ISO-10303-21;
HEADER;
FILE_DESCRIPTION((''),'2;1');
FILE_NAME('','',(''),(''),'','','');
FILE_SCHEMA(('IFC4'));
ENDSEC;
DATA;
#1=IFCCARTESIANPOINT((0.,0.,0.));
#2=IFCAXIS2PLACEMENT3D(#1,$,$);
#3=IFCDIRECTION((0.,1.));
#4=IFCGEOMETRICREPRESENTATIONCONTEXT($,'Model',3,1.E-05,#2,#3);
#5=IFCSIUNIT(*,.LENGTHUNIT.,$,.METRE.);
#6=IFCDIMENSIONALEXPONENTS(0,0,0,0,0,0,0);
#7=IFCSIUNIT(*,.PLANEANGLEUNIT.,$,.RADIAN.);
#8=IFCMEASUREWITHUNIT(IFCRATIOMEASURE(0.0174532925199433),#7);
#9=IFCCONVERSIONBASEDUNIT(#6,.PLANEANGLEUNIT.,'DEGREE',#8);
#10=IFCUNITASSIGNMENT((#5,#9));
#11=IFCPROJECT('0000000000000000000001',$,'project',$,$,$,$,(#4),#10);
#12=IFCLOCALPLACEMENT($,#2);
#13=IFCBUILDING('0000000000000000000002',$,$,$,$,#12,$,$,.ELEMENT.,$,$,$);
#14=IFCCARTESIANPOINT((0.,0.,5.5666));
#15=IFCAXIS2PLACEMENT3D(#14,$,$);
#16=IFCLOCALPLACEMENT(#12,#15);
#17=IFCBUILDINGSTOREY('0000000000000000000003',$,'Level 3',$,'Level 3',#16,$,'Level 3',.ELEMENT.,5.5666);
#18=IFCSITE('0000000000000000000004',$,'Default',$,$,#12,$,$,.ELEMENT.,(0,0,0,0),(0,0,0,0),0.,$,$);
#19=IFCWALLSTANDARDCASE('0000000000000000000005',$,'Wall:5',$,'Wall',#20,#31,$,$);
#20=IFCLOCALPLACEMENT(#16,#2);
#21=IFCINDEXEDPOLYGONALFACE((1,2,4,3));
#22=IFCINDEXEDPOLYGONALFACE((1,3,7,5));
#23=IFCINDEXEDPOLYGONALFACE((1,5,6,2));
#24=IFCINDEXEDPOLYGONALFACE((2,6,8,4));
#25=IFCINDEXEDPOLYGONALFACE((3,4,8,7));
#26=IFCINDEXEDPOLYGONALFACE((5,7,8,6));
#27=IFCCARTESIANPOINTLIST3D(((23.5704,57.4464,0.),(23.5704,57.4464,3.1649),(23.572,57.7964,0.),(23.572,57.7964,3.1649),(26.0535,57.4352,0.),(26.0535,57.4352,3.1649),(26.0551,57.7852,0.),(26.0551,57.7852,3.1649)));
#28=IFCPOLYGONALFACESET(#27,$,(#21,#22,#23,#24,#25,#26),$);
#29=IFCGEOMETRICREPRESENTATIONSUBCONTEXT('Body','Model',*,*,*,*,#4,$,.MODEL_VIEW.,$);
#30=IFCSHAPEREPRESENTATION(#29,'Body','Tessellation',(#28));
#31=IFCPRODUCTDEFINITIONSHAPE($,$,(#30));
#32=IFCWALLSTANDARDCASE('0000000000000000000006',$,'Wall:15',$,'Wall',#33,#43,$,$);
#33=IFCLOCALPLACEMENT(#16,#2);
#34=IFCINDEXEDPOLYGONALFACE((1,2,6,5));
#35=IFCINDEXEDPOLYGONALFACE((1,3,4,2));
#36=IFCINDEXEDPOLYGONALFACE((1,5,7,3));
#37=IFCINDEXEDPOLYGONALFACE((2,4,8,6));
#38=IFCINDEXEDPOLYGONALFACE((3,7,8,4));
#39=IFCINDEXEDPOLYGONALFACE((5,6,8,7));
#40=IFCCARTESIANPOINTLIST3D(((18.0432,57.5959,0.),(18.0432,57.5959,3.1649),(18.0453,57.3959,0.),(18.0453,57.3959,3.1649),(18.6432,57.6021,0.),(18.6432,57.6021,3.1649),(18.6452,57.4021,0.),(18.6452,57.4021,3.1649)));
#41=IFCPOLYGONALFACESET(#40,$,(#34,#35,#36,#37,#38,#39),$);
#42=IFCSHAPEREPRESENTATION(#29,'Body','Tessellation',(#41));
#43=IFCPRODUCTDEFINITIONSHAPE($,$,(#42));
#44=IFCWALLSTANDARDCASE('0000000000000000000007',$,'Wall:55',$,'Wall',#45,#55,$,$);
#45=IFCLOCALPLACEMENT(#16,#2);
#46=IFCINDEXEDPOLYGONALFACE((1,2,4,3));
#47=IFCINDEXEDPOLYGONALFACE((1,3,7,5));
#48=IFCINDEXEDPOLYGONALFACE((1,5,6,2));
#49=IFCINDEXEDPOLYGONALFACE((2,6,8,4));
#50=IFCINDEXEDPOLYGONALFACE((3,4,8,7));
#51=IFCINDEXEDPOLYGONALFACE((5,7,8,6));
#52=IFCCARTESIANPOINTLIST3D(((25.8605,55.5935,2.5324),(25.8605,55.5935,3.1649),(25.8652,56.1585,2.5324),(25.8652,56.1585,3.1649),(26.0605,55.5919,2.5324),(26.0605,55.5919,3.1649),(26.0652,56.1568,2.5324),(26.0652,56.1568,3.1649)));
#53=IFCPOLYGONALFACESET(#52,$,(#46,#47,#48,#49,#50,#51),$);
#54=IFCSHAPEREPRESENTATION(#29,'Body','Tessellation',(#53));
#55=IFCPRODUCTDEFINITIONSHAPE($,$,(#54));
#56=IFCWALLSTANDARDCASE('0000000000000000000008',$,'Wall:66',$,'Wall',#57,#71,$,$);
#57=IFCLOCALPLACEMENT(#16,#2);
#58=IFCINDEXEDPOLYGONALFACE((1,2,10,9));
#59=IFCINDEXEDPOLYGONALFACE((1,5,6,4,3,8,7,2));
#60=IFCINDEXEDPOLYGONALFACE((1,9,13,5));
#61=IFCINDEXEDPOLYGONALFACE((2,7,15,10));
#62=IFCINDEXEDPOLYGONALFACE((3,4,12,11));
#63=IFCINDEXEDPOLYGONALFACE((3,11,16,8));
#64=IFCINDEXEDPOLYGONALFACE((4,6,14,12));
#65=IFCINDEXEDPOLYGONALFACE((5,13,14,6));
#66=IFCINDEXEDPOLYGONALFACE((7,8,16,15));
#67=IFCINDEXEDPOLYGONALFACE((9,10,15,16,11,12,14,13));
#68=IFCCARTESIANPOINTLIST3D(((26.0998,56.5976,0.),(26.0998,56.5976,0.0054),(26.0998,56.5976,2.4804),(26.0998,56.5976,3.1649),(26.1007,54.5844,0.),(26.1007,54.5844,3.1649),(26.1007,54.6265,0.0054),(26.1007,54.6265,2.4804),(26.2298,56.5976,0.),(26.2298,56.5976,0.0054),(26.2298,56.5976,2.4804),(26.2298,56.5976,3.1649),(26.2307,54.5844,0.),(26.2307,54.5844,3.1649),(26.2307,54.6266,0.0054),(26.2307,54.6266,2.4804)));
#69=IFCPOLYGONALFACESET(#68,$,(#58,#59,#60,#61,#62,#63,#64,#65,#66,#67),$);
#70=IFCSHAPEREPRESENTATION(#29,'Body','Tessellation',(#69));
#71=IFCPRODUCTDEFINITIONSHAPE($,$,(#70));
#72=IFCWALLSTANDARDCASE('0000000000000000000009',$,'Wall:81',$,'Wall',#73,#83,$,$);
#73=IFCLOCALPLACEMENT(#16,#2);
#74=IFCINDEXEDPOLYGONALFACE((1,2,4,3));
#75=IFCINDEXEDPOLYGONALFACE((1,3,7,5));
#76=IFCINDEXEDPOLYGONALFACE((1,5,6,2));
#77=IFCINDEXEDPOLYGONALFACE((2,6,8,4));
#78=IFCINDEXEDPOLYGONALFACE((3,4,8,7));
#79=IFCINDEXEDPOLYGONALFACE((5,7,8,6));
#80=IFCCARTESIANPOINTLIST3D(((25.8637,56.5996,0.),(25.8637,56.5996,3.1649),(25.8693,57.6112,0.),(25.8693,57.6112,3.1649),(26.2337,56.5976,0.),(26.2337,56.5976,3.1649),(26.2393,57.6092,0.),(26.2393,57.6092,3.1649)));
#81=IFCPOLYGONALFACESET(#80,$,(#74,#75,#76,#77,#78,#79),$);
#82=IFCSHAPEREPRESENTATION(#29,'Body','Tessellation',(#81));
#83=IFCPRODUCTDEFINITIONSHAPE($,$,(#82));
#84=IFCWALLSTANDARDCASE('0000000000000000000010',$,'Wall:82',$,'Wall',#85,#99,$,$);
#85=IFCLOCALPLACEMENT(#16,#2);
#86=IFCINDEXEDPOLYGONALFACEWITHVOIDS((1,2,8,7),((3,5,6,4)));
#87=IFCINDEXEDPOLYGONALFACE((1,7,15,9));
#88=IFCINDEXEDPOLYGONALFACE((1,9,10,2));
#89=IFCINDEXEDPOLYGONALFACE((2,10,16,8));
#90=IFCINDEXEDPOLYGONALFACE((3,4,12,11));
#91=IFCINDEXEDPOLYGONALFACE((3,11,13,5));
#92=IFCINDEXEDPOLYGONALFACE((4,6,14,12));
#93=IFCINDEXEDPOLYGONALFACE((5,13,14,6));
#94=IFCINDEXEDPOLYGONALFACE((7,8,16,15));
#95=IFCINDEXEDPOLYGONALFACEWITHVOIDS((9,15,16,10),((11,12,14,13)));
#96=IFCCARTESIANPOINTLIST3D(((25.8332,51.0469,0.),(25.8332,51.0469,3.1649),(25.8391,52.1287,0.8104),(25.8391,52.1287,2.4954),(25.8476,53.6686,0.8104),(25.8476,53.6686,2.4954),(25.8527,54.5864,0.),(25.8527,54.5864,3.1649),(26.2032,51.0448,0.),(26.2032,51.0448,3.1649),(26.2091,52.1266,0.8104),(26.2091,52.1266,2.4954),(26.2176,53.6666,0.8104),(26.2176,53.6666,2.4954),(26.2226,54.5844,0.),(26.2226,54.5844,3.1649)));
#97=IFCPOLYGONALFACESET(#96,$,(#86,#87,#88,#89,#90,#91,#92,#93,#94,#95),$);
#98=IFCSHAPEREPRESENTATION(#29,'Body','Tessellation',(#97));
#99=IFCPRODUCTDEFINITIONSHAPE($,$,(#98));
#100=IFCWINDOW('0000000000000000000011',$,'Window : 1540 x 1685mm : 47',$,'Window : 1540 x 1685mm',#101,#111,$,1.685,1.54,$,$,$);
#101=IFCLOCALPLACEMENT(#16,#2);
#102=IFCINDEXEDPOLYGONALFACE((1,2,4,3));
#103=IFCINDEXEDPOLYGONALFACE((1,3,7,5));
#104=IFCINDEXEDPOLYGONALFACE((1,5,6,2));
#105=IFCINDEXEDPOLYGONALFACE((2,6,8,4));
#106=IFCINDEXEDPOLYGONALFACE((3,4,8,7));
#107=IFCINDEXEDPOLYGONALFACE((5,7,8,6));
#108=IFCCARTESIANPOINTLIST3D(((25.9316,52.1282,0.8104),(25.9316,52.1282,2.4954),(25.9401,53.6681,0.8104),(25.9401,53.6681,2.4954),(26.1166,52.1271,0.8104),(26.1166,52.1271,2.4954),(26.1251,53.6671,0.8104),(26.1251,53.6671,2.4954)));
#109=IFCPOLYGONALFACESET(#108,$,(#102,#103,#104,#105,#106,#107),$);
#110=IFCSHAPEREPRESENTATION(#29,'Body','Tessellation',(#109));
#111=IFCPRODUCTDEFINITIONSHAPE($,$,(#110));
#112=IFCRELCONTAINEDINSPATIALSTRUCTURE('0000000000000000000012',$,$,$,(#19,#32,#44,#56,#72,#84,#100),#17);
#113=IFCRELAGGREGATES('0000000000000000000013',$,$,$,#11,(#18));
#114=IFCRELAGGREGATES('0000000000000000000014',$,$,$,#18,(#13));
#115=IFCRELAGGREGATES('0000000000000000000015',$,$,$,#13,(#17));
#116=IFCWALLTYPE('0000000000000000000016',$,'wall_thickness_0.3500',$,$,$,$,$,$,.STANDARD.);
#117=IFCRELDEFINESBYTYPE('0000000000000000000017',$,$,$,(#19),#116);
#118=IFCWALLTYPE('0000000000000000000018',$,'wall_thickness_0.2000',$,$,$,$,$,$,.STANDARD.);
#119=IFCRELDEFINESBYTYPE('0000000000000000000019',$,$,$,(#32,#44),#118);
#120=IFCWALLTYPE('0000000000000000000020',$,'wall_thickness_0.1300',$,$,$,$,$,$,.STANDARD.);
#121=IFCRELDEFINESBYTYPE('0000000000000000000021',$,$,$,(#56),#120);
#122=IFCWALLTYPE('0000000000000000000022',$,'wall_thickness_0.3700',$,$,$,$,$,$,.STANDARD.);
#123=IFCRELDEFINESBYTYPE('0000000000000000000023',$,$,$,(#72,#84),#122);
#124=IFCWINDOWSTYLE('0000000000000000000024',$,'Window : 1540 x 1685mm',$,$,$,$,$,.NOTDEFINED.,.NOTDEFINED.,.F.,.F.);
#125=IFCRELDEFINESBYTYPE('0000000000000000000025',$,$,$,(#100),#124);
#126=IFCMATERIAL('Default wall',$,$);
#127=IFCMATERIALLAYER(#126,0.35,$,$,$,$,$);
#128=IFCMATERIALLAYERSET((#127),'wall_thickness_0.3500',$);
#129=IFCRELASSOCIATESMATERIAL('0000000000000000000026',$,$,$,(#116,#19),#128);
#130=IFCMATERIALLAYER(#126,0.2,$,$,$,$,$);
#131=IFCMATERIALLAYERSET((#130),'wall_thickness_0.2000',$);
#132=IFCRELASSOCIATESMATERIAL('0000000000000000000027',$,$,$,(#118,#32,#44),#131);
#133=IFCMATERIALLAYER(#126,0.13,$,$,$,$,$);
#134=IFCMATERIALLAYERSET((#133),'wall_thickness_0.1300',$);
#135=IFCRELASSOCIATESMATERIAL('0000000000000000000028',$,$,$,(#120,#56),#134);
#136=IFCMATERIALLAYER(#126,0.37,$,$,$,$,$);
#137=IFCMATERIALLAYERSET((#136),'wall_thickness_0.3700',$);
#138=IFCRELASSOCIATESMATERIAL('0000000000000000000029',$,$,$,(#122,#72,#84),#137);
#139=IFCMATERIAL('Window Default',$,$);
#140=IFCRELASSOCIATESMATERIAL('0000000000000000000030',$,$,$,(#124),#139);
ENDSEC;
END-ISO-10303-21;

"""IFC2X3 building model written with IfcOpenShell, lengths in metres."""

from ifc_helpers import new_model, entity, si_unit, converted_unit, direction, frame, frame_2d, origin, origin_2d_with_axis, place, context, subcontext, project, spatial, polyline, rectangle, outline, extrude, source, transform, mapped, material, layer, layer_set, layer_usage, type_object, type_shapes, element, fill, save


model = new_model("IFC2X3")

# Units and contexts
model_context = context("Model", 3, precision=1e-05, world=origin(), true_north=direction((0.0, 1.0)))
body_context = subcontext(model_context, "Body", "Model", "MODEL_VIEW")
ifc_project = project(units=[si_unit("LENGTHUNIT", "METRE"), converted_unit("PLANEANGLEUNIT", "DEGREE", entity("IfcRatioMeasure", 0.0174532925199433), si_unit("PLANEANGLEUNIT", "RADIAN"), dimensions=[0, 0, 0, 0, 0, 0, 0])], contexts=[model_context])

# Site, building, storey
placement_1 = place(None, origin())
site = spatial("IfcSite", under=ifc_project, at=placement_1, Name="Default", CompositionType="ELEMENT", RefLatitude=(0, 0, 0, 0), RefLongitude=(0, 0, 0, 0), RefElevation=0.0)
building = spatial("IfcBuilding", under=site, at=placement_1, CompositionType="ELEMENT")
storey_placement = place(placement_1, frame((0.0, 0.0, 5.5666)))
storey = spatial("IfcBuildingStorey", under=building, at=storey_placement, Name="Level 3", ObjectType="Level 3", LongName="Level 3", CompositionType="ELEMENT", Elevation=5.5666)

# Walls
ifc_material_1 = material(Name="Default wall")
ifc_layer_1 = layer(ifc_material_1, 0.35)
ifc_layer_set_1 = layer_set([ifc_layer_1], Name="wall_thickness_0.3500")
ifc_layer_usage_1 = layer_usage(ifc_layer_set_1, "AXIS2", "POSITIVE", -0.175)
wall_type_1 = type_object("IfcWallType", Name="wall_thickness_0.3500", PredefinedType="STANDARD", material=ifc_layer_set_1)
wall_1_placement = place(storey_placement, frame((23.5712, 57.6214, 0.0), z_axis=(0.0, 0.0, 1.0), x_axis=(0.99999, -0.004532, 0.0)))
element("IfcWallStandardCase", 1, at=wall_1_placement, inside=storey, type_object=wall_type_1, material=ifc_layer_usage_1, Name="Wall:5", ObjectType="Wall", context=body_context, shape_type="SweptSolid", body=[
    extrude(outline(polyline([(2.4831, -0.175), (2.4831, 0.175), (0.0, 0.175), (0.0, -0.175), (2.4831, -0.175)])), origin(), (0.0, 0.0, 1.0), 3.1649),
])
ifc_layer_2 = layer(ifc_material_1, 0.2)
ifc_layer_set_2 = layer_set([ifc_layer_2], Name="wall_thickness_0.2000")
ifc_layer_usage_2 = layer_usage(ifc_layer_set_2, "AXIS2", "POSITIVE", -0.1)
wall_type_2 = type_object("IfcWallType", Name="wall_thickness_0.2000", PredefinedType="STANDARD", material=ifc_layer_set_2)
wall_2_placement = place(storey_placement, frame((18.6442, 57.5021, 0.0), z_axis=(0.0, 0.0, 1.0), x_axis=(-0.999947, -0.010338, 0.0)))
element("IfcWallStandardCase", 2, at=wall_2_placement, inside=storey, type_object=wall_type_2, material=ifc_layer_usage_2, Name="Wall:15", ObjectType="Wall", context=body_context, shape_type="SweptSolid", body=[
    extrude(outline(polyline([(0.6, -0.1), (0.6, 0.1), (0.0, 0.1), (0.0, -0.1), (0.6, -0.1)])), origin(), (0.0, 0.0, 1.0), 3.1649),
])
placement_2 = place(placement_1, frame((0.0, 0.0, 8.099)))
wall_3_placement = place(placement_2, frame((25.9652, 56.1577, 0.0), z_axis=(0.0, 0.0, 1.0), x_axis=(-0.008247, -0.999966, 0.0)))
element("IfcWallStandardCase", 3, at=wall_3_placement, inside=storey, type_object=wall_type_2, material=ifc_layer_usage_2, Name="Wall:55", ObjectType="Wall", context=body_context, shape_type="SweptSolid", body=[
    extrude(outline(polyline([(0.565, -0.1), (0.565, 0.1), (0.0, 0.1), (0.0, -0.1), (0.565, -0.1)])), origin(), (0.0, 0.0, 1.0), 0.6325),
])

# Wall, opening
ifc_layer_3 = layer(ifc_material_1, 0.13)
ifc_layer_set_3 = layer_set([ifc_layer_3], Name="wall_thickness_0.1300")
ifc_layer_usage_3 = layer_usage(ifc_layer_set_3, "AXIS2", "POSITIVE", -0.065)
wall_type_3 = type_object("IfcWallType", Name="wall_thickness_0.1300", PredefinedType="STANDARD", material=ifc_layer_set_3)
wall_4_placement = place(storey_placement, frame((26.1648, 56.5976, 0.0), z_axis=(0.0, 0.0, 1.0), x_axis=(0.000459, -1.0, 0.0)))
wall_4 = element("IfcWallStandardCase", 4, at=wall_4_placement, inside=storey, type_object=wall_type_3, material=ifc_layer_usage_3, Name="Wall:66", ObjectType="Wall", context=body_context, shape_type="SweptSolid", body=[
    extrude(outline(polyline([(2.0132, -0.065), (2.0132, 0.065), (0.0, 0.065), (0.0, -0.065), (2.0132, -0.065)])), origin(), (0.0, 0.0, 1.0), 3.1649),
])
opening_1_placement = place(wall_4_placement, frame((-0.014, -0.065, 0.0054)))
element("IfcOpeningElement", 5, at=opening_1_placement, cuts=wall_4, ObjectType="Opening", context=body_context, shape_type="SweptSolid", body=[
    extrude(rectangle(XDim=1.985, YDim=2.475, at=frame_2d((1.2375, 0.9925), x_axis=(0.0, 1.0))), frame((0.0, 0.0, 0.0), z_axis=(0.0, 1.0, 0.0), x_axis=(0.0, 0.0, 1.0)), (0.0, 0.0, 1.0), 0.13),
])

# Wall
ifc_layer_4 = layer(ifc_material_1, 0.37)
ifc_layer_set_4 = layer_set([ifc_layer_4], Name="wall_thickness_0.3700")
ifc_layer_usage_4 = layer_usage(ifc_layer_set_4, "AXIS2", "POSITIVE", -0.185)
wall_type_4 = type_object("IfcWallType", Name="wall_thickness_0.3700", PredefinedType="STANDARD", material=ifc_layer_set_4)
wall_5_placement = place(storey_placement, frame((26.0543, 57.6102, 0.0), z_axis=(0.0, 0.0, 1.0), x_axis=(-0.005498, -0.999985, 0.0)))
element("IfcWallStandardCase", 6, at=wall_5_placement, inside=storey, type_object=wall_type_4, material=ifc_layer_usage_4, Name="Wall:81", ObjectType="Wall", context=body_context, shape_type="SweptSolid", body=[
    extrude(outline(polyline([(1.0116, -0.185), (1.0116, 0.185), (0.0, 0.185), (0.0, -0.185), (1.0116, -0.185)])), origin(), (0.0, 0.0, 1.0), 3.1649),
])

# Wall, opening, window
wall_6_placement = place(storey_placement, frame((26.0376, 54.5854, 0.0), z_axis=(0.0, 0.0, 1.0), x_axis=(-0.005497, -0.999985, 0.0)))
wall_6 = element("IfcWallStandardCase", 7, at=wall_6_placement, inside=storey, type_object=wall_type_4, material=ifc_layer_usage_4, Name="Wall:82", ObjectType="Wall", context=body_context, shape_type="SweptSolid", body=[
    extrude(outline(polyline([(3.5396, -0.185), (3.5396, 0.185), (0.0, 0.185), (0.0, -0.185), (3.5396, -0.185)])), origin(), (0.0, 0.0, 1.0), 3.1649),
])
opening_2_placement = place(wall_6_placement, frame((0.9178, -0.185, 0.8104)))
opening_2 = element("IfcOpeningElement", 8, at=opening_2_placement, cuts=wall_6, ObjectType="Opening", context=body_context, shape_type="SweptSolid", body=[
    extrude(rectangle(XDim=1.54, YDim=1.685, at=frame_2d((0.8425, 0.77), x_axis=(0.0, 1.0))), frame((0.0, 0.0, 0.0), z_axis=(0.0, 1.0, 0.0), x_axis=(0.0, 0.0, 1.0)), (0.0, 0.0, 1.0), 0.37),
])
ifc_material_2 = material(Name="Window Default")
window_style = type_object("IfcWindowStyle", Name="Window : 1540 x 1685mm", ConstructionType="NOTDEFINED", OperationType="NOTDEFINED", ParameterTakesPrecedence=False, Sizeable=False, material=ifc_material_2)
shared_shape = source(origin(), body_context, "Body", "SweptSolid", [
    extrude(rectangle(XDim=0.185, YDim=1.54, at=origin_2d_with_axis()), frame((0.77, 0.185, 0.0), z_axis=(0.0, 0.0, 1.0), x_axis=(0.0, 1.0, 0.0)), (0.0, 0.0, 1.0), 1.685),
])
type_shapes(window_style, [shared_shape])
window_placement = place(opening_2_placement, origin())
window = element("IfcWindow", 9, at=window_placement, inside=storey, type_object=window_style, Name="Window : 1540 x 1685mm : 47", ObjectType="Window : 1540 x 1685mm", OverallHeight=1.685, OverallWidth=1.54, context=body_context, shape_type="MappedRepresentation", body=[
    mapped(shared_shape, transform((0.0, 0.0, 0.0), scale=1.0)),
])
fill(opening_2, window)

save(model, "model.ifc")
